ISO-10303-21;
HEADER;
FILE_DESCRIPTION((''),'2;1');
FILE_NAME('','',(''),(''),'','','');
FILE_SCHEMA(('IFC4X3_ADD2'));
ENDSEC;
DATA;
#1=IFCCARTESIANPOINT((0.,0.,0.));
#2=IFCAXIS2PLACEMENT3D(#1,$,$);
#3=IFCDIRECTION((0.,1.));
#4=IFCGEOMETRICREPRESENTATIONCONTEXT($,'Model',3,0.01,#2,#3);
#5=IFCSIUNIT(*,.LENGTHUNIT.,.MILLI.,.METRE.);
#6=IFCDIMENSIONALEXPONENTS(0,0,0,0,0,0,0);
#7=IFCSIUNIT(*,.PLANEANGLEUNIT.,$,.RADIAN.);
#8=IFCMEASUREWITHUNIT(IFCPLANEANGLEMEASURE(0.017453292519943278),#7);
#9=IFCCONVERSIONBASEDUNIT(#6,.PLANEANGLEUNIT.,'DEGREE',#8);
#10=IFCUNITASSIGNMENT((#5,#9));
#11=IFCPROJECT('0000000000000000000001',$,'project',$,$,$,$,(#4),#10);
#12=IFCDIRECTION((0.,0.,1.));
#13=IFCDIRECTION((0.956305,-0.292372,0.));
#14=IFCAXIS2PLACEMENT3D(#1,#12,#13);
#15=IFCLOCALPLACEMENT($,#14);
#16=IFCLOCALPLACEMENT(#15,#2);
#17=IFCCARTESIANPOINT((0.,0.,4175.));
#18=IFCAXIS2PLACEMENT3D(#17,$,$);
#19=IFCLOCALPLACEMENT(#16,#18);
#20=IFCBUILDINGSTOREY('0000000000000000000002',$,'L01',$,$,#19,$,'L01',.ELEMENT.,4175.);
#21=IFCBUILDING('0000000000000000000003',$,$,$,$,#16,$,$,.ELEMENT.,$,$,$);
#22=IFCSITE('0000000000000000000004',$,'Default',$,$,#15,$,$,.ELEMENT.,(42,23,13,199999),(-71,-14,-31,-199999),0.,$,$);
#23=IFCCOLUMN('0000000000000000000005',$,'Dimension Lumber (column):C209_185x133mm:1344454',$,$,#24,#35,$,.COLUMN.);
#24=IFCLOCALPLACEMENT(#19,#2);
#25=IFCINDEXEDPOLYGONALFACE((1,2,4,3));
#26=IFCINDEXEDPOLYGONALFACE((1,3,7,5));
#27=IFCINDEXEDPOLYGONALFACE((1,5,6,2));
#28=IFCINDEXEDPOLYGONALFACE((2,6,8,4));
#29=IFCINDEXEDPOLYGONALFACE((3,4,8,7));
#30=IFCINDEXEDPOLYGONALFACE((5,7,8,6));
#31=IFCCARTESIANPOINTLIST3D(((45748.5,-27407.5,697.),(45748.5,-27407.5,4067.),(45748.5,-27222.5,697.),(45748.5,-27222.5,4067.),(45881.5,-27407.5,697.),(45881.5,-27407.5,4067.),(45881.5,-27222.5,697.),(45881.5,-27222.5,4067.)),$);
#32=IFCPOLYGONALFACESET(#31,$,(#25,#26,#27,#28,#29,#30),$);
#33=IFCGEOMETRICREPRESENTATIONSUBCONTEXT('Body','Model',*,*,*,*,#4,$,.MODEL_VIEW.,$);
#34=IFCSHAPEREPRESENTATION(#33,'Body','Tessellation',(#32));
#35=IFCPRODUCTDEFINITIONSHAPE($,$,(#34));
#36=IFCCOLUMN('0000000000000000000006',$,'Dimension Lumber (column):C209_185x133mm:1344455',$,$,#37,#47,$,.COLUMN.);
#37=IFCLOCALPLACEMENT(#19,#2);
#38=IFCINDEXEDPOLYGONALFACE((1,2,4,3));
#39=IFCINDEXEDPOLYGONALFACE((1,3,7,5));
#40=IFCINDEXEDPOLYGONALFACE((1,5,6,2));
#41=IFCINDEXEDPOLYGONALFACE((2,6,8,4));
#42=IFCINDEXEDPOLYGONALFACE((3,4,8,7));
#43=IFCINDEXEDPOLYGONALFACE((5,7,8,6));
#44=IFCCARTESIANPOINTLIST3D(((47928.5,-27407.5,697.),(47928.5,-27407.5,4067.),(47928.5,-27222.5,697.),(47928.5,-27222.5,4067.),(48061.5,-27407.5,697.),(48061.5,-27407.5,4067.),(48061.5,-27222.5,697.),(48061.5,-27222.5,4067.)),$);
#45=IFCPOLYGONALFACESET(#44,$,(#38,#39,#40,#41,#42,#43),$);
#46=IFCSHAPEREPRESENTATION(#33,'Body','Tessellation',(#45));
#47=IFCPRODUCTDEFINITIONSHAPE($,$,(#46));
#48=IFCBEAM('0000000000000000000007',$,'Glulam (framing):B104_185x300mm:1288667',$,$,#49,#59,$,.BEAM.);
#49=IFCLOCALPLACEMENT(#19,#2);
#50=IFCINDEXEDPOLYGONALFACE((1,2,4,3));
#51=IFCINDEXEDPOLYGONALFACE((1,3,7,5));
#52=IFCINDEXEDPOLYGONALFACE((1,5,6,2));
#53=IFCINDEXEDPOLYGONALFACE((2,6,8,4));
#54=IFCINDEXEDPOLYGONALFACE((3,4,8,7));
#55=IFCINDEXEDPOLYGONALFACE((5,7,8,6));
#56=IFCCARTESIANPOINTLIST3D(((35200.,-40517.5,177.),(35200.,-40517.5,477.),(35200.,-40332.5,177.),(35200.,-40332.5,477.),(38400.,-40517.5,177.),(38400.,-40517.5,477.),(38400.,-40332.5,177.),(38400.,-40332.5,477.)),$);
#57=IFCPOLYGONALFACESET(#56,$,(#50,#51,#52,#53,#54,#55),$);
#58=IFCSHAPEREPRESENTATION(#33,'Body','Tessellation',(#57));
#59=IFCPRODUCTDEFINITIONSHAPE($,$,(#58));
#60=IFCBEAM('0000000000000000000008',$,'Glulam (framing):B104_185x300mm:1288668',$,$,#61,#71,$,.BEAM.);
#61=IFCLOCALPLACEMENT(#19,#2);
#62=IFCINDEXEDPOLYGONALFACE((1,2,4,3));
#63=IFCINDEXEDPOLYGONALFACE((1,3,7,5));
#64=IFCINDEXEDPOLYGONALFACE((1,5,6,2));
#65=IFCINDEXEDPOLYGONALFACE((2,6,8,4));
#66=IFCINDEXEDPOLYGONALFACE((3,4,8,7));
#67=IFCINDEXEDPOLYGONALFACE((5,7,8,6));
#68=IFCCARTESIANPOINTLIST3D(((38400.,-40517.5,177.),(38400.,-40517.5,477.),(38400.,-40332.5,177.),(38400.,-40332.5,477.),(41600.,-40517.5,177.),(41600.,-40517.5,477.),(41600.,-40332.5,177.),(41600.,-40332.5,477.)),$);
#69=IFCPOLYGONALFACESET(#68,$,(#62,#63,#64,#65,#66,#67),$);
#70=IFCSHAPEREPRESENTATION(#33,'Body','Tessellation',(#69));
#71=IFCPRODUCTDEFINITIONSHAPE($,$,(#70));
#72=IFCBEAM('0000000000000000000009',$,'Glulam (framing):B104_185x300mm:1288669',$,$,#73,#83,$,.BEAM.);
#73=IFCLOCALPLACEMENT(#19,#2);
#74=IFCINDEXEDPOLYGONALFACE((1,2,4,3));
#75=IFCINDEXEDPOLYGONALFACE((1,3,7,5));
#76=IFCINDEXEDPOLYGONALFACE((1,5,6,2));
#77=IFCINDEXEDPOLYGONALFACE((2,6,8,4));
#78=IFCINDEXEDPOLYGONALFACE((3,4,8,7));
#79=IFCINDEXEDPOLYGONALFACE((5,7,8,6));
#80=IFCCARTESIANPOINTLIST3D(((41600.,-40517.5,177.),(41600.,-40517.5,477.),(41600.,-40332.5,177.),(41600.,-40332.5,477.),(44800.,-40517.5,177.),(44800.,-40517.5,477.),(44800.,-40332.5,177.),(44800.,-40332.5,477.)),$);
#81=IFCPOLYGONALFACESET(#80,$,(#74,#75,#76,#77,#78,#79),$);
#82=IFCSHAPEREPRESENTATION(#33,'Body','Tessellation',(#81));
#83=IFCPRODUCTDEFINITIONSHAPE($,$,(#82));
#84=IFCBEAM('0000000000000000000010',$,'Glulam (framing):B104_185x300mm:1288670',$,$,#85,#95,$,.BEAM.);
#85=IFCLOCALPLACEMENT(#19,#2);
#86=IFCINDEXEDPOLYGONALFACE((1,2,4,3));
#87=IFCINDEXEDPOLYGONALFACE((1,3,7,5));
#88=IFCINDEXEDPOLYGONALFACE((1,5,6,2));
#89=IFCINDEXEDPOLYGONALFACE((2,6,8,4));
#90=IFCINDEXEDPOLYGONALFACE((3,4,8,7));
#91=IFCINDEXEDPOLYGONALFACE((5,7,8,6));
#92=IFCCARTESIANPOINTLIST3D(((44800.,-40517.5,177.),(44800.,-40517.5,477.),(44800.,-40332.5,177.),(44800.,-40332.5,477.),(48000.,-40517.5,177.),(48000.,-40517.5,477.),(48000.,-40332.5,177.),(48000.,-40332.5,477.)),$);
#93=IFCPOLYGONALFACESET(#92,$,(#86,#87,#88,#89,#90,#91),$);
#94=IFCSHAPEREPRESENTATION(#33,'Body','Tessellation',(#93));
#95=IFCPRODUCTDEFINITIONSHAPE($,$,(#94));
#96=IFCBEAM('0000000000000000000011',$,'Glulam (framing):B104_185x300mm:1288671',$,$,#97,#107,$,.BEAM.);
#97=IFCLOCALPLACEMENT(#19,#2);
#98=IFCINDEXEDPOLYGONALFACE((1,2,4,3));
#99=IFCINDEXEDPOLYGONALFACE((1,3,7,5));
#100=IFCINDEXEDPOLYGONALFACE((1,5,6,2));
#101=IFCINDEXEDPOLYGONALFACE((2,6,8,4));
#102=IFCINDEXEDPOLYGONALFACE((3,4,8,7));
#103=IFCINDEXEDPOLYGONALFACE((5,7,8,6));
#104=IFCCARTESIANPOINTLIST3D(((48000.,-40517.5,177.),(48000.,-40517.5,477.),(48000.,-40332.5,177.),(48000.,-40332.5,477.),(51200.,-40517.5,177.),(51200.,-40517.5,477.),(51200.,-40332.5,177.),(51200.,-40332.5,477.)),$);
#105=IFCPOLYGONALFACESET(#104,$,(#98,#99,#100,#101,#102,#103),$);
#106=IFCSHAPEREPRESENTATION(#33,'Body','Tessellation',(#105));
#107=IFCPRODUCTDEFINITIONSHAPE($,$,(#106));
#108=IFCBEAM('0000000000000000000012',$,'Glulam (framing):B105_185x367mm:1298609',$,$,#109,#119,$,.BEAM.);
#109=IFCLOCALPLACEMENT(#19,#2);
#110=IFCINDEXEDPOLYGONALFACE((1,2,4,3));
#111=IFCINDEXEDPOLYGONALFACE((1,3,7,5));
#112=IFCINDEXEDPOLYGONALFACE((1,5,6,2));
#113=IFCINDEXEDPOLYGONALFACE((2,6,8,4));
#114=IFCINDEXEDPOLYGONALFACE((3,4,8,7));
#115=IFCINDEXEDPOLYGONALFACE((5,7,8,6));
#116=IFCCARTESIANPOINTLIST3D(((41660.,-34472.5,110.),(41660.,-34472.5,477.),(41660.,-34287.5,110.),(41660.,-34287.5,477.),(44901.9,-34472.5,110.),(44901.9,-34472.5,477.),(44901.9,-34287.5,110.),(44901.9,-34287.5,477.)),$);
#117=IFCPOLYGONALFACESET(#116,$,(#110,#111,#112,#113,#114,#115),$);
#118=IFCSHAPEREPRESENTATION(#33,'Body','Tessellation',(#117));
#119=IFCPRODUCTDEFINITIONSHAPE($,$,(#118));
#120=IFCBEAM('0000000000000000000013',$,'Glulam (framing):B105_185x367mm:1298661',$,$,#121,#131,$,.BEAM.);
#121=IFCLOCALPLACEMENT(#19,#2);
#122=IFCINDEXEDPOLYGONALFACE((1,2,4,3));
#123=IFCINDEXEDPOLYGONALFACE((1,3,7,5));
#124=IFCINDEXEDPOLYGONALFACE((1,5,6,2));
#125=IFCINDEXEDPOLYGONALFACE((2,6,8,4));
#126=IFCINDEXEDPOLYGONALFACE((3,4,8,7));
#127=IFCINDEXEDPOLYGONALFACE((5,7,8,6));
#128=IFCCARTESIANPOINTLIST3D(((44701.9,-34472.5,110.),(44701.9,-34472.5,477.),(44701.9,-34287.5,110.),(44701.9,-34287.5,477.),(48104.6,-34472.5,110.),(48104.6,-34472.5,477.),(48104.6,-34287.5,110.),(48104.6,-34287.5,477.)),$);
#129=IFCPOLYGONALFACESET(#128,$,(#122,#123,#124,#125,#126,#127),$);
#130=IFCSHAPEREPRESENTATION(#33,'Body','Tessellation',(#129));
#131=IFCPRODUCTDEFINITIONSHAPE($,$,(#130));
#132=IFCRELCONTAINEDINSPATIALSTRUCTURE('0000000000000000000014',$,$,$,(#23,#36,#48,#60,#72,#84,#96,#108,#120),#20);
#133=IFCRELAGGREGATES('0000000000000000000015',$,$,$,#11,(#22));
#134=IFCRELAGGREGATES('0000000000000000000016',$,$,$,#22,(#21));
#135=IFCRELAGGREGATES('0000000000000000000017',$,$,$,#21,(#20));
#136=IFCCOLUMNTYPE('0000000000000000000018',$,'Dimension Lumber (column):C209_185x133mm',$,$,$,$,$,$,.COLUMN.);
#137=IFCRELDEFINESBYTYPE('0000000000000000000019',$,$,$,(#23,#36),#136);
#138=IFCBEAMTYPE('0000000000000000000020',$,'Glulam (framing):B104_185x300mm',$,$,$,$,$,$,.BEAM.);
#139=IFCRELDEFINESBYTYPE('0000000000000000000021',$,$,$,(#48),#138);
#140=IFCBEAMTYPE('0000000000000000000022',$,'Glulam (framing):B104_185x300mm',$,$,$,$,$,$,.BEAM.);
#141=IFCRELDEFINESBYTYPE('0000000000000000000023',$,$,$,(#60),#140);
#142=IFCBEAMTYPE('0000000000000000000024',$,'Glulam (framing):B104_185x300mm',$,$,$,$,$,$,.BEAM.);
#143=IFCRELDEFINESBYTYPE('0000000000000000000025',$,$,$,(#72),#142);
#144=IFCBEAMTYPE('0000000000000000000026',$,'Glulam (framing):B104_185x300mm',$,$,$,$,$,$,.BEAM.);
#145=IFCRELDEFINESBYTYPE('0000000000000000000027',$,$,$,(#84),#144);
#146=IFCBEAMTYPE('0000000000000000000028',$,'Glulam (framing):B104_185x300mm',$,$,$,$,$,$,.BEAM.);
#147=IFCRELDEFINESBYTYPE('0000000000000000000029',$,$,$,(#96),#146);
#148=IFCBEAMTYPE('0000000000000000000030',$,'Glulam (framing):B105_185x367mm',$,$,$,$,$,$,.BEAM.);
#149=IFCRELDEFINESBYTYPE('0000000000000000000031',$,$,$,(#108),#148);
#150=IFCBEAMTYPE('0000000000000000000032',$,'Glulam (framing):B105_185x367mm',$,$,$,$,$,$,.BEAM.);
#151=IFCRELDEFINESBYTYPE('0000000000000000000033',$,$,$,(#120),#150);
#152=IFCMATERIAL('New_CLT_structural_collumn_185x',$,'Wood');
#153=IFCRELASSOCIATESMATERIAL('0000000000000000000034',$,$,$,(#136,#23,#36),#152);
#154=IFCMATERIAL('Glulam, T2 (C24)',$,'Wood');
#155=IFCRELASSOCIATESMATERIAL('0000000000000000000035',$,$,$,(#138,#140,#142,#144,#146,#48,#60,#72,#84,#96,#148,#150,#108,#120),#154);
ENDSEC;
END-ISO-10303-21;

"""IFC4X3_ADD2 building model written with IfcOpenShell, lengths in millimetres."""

from ifc_helpers import new_model, entity, si_unit, converted_unit, direction, frame, origin, origin_2d_with_axis, place, context, subcontext, project, spatial, rectangle, extrude, source, transform, mapped, material, material_profile, profile_set, profile_usage, type_object, type_shapes, element, save


model = new_model("IFC4X3_ADD2")

# Units and contexts
model_context = context("Model", 3, precision=0.01, world=origin(), true_north=direction((0.0, 1.0)))
body_context = subcontext(model_context, "Body", "Model", "MODEL_VIEW")
ifc_project = project(units=[si_unit("LENGTHUNIT", "METRE", prefix="MILLI"), converted_unit("PLANEANGLEUNIT", "DEGREE", entity("IfcPlaneAngleMeasure", 0.017453292519943278), si_unit("PLANEANGLEUNIT", "RADIAN"), dimensions=[0, 0, 0, 0, 0, 0, 0])], contexts=[model_context])

# Site, building, storey
site_placement = place(None, frame((0.0, 0.0, 0.0), z_axis=(0.0, 0.0, 1.0), x_axis=(0.956305, -0.292372, 0.0)))
site = spatial("IfcSite", under=ifc_project, at=site_placement, Name="Default", CompositionType="ELEMENT", RefLatitude=(42, 23, 13, 199999), RefLongitude=(-71, -14, -31, -199999), RefElevation=0.0)
building_placement = place(site_placement, origin())
building = spatial("IfcBuilding", under=site, at=building_placement, CompositionType="ELEMENT")
storey_placement = place(building_placement, frame((0.0, 0.0, 4175.0)))
storey = spatial("IfcBuildingStorey", under=building, at=storey_placement, Name="L01", LongName="L01", CompositionType="ELEMENT", Elevation=4175.0)

# Columns
ifc_material_1 = material(Name="New_CLT_structural_collumn_185x", Category="Wood")
ifc_material_profile_1 = material_profile(ifc_material_1, rectangle(XDim=185.0, YDim=133.0, at=origin_2d_with_axis()), Name="C209_185x133mm")
ifc_profile_set_1 = profile_set([ifc_material_profile_1], Name="C209_185x133mm")
ifc_profile_usage_1 = profile_usage(ifc_profile_set_1)
column_type_1 = type_object("IfcColumnType", Name="Dimension Lumber (column):C209_185x133mm", PredefinedType="COLUMN", material=ifc_profile_set_1)
shared_shape_1 = source(origin(), body_context, "Body", "SweptSolid", [
    extrude(rectangle(XDim=185.0, YDim=133.0, at=origin_2d_with_axis()), frame((0.0, 0.0, 4872.0), z_axis=(0.0, 0.0, 1.0), x_axis=(-1.0, 0.0, 0.0)), (0.0, 0.0, 1.0), 3370.0),
])
type_shapes(column_type_1, [shared_shape_1])
for number, where, z_axis, x_axis, name in (
    (1, (45815.0, -27315.0, -4175.0), (0.0, 0.0, 1.0), (0.0, 1.0, 0.0), "Dimension Lumber (column):C209_185x133mm:1344454"),
    (2, (47995.0, -27315.0, -4175.0), (0.0, 0.0, 1.0), (0.0, 1.0, 0.0), "Dimension Lumber (column):C209_185x133mm:1344455"),
):
    element("IfcColumn", number, at=place(storey_placement, frame(where, z_axis=z_axis, x_axis=x_axis)), inside=storey, type_object=column_type_1, material=ifc_profile_usage_1, Name=name, PredefinedType="COLUMN", context=body_context, shape_type="MappedRepresentation", body=[
        mapped(shared_shape_1, transform((0.0, 0.0, 0.0), scale=1.0)),
    ])

# Beams
ifc_material_2 = material(Name="Glulam, T2 (C24)", Category="Wood")
ifc_material_profile_2 = material_profile(ifc_material_2, rectangle(XDim=3380.0, YDim=185.0, at=origin_2d_with_axis()), Name="B104_185x300mm")
ifc_profile_set_2 = profile_set([ifc_material_profile_2], Name="B104_185x300mm")
ifc_profile_usage_2 = profile_usage(ifc_profile_set_2, cardinal=8)
beam_type_1 = type_object("IfcBeamType", Name="Glulam (framing):B104_185x300mm", PredefinedType="BEAM", material=ifc_profile_set_2)
shared_shape_2 = source(origin(), body_context, "Body", "SweptSolid", [
    extrude(rectangle(XDim=3200.0, YDim=185.0, at=origin_2d_with_axis()), frame((0.0, 0.0, -150.0), z_axis=(0.0, 0.0, 1.0), x_axis=(-1.0, 0.0, 0.0)), (0.0, 0.0, 1.0), 300.0),
])
type_shapes(beam_type_1, [shared_shape_2])
beam_1_placement = place(storey_placement, frame((36800.0, -40425.0, 327.0)))
element("IfcBeam", 3, at=beam_1_placement, inside=storey, type_object=beam_type_1, material=ifc_profile_usage_2, Name="Glulam (framing):B104_185x300mm:1288667", PredefinedType="BEAM", context=body_context, shape_type="MappedRepresentation", body=[
    mapped(shared_shape_2, transform((0.0, 0.0, 0.0), scale=1.0)),
])
beam_type_2 = type_object("IfcBeamType", Name="Glulam (framing):B104_185x300mm", PredefinedType="BEAM", material=ifc_profile_set_2)
shared_shape_3 = source(origin(), body_context, "Body", "SweptSolid", [
    extrude(rectangle(XDim=3200.0, YDim=185.0, at=origin_2d_with_axis()), frame((0.0, 0.0, -150.0), z_axis=(0.0, 0.0, 1.0), x_axis=(-1.0, 0.0, 0.0)), (0.0, 0.0, 1.0), 300.0),
])
type_shapes(beam_type_2, [shared_shape_3])
beam_2_placement = place(storey_placement, frame((40000.0, -40425.0, 327.0)))
element("IfcBeam", 4, at=beam_2_placement, inside=storey, type_object=beam_type_2, material=ifc_profile_usage_2, Name="Glulam (framing):B104_185x300mm:1288668", PredefinedType="BEAM", context=body_context, shape_type="MappedRepresentation", body=[
    mapped(shared_shape_3, transform((0.0, 0.0, 0.0), scale=1.0)),
])
beam_type_3 = type_object("IfcBeamType", Name="Glulam (framing):B104_185x300mm", PredefinedType="BEAM", material=ifc_profile_set_2)
shared_shape_4 = source(origin(), body_context, "Body", "SweptSolid", [
    extrude(rectangle(XDim=3200.0, YDim=185.0, at=origin_2d_with_axis()), frame((0.0, 0.0, -150.0), z_axis=(0.0, 0.0, 1.0), x_axis=(-1.0, 0.0, 0.0)), (0.0, 0.0, 1.0), 300.0),
])
type_shapes(beam_type_3, [shared_shape_4])
beam_3_placement = place(storey_placement, frame((43200.0, -40425.0, 327.0)))
element("IfcBeam", 5, at=beam_3_placement, inside=storey, type_object=beam_type_3, material=ifc_profile_usage_2, Name="Glulam (framing):B104_185x300mm:1288669", PredefinedType="BEAM", context=body_context, shape_type="MappedRepresentation", body=[
    mapped(shared_shape_4, transform((0.0, 0.0, 0.0), scale=1.0)),
])
beam_type_4 = type_object("IfcBeamType", Name="Glulam (framing):B104_185x300mm", PredefinedType="BEAM", material=ifc_profile_set_2)
shared_shape_5 = source(origin(), body_context, "Body", "SweptSolid", [
    extrude(rectangle(XDim=3200.0, YDim=185.0, at=origin_2d_with_axis()), frame((0.0, 0.0, -150.0), z_axis=(0.0, 0.0, 1.0), x_axis=(-1.0, 0.0, 0.0)), (0.0, 0.0, 1.0), 300.0),
])
type_shapes(beam_type_4, [shared_shape_5])
beam_4_placement = place(storey_placement, frame((46400.0, -40425.0, 327.0)))
element("IfcBeam", 6, at=beam_4_placement, inside=storey, type_object=beam_type_4, material=ifc_profile_usage_2, Name="Glulam (framing):B104_185x300mm:1288670", PredefinedType="BEAM", context=body_context, shape_type="MappedRepresentation", body=[
    mapped(shared_shape_5, transform((0.0, 0.0, 0.0), scale=1.0)),
])
beam_type_5 = type_object("IfcBeamType", Name="Glulam (framing):B104_185x300mm", PredefinedType="BEAM", material=ifc_profile_set_2)
shared_shape_6 = source(origin(), body_context, "Body", "SweptSolid", [
    extrude(rectangle(XDim=3200.0, YDim=185.0, at=origin_2d_with_axis()), frame((0.0, 0.0, -150.0), z_axis=(0.0, 0.0, 1.0), x_axis=(-1.0, 0.0, 0.0)), (0.0, 0.0, 1.0), 300.0),
])
type_shapes(beam_type_5, [shared_shape_6])
beam_5_placement = place(storey_placement, frame((49600.0, -40425.0, 327.0)))
element("IfcBeam", 7, at=beam_5_placement, inside=storey, type_object=beam_type_5, material=ifc_profile_usage_2, Name="Glulam (framing):B104_185x300mm:1288671", PredefinedType="BEAM", context=body_context, shape_type="MappedRepresentation", body=[
    mapped(shared_shape_6, transform((0.0, 0.0, 0.0), scale=1.0)),
])
ifc_material_profile_3 = material_profile(ifc_material_2, rectangle(XDim=3241.9, YDim=185.0, at=origin_2d_with_axis()), Name="B105_185x367mm")
ifc_profile_set_3 = profile_set([ifc_material_profile_3], Name="B105_185x367mm")
ifc_profile_usage_3 = profile_usage(ifc_profile_set_3, cardinal=8)
beam_type_6 = type_object("IfcBeamType", Name="Glulam (framing):B105_185x367mm", PredefinedType="BEAM", material=ifc_profile_set_3)
shared_shape_7 = source(origin(), body_context, "Body", "SweptSolid", [
    extrude(rectangle(XDim=3241.9, YDim=185.0, at=origin_2d_with_axis()), frame((80.0, 0.0, -183.5), z_axis=(0.0, 0.0, 1.0), x_axis=(-1.0, 0.0, 0.0)), (0.0, 0.0, 1.0), 367.0),
])
type_shapes(beam_type_6, [shared_shape_7])
beam_6_placement = place(storey_placement, frame((43201.0, -34380.0, 293.5)))
element("IfcBeam", 8, at=beam_6_placement, inside=storey, type_object=beam_type_6, material=ifc_profile_usage_3, Name="Glulam (framing):B105_185x367mm:1298609", PredefinedType="BEAM", context=body_context, shape_type="MappedRepresentation", body=[
    mapped(shared_shape_7, transform((0.0, 0.0, 0.0), scale=1.0)),
])
beam_type_7 = type_object("IfcBeamType", Name="Glulam (framing):B105_185x367mm", PredefinedType="BEAM", material=ifc_profile_set_3)
shared_shape_8 = source(origin(), body_context, "Body", "SweptSolid", [
    extrude(rectangle(XDim=3402.7, YDim=185.0, at=origin_2d_with_axis()), frame((0.0, 0.0, -183.5), z_axis=(0.0, 0.0, 1.0), x_axis=(-1.0, 0.0, 0.0)), (0.0, 0.0, 1.0), 367.0),
])
type_shapes(beam_type_7, [shared_shape_8])
beam_7_placement = place(storey_placement, frame((46403.3, -34380.0, 293.5), z_axis=(0.0, 0.0, 1.0), x_axis=(-1.0, 0.0, 0.0)))
element("IfcBeam", 9, at=beam_7_placement, inside=storey, type_object=beam_type_7, material=ifc_profile_usage_3, Name="Glulam (framing):B105_185x367mm:1298661", PredefinedType="BEAM", context=body_context, shape_type="MappedRepresentation", body=[
    mapped(shared_shape_8, transform((0.0, 0.0, 0.0), scale=1.0)),
])

save(model, "model.ifc")
